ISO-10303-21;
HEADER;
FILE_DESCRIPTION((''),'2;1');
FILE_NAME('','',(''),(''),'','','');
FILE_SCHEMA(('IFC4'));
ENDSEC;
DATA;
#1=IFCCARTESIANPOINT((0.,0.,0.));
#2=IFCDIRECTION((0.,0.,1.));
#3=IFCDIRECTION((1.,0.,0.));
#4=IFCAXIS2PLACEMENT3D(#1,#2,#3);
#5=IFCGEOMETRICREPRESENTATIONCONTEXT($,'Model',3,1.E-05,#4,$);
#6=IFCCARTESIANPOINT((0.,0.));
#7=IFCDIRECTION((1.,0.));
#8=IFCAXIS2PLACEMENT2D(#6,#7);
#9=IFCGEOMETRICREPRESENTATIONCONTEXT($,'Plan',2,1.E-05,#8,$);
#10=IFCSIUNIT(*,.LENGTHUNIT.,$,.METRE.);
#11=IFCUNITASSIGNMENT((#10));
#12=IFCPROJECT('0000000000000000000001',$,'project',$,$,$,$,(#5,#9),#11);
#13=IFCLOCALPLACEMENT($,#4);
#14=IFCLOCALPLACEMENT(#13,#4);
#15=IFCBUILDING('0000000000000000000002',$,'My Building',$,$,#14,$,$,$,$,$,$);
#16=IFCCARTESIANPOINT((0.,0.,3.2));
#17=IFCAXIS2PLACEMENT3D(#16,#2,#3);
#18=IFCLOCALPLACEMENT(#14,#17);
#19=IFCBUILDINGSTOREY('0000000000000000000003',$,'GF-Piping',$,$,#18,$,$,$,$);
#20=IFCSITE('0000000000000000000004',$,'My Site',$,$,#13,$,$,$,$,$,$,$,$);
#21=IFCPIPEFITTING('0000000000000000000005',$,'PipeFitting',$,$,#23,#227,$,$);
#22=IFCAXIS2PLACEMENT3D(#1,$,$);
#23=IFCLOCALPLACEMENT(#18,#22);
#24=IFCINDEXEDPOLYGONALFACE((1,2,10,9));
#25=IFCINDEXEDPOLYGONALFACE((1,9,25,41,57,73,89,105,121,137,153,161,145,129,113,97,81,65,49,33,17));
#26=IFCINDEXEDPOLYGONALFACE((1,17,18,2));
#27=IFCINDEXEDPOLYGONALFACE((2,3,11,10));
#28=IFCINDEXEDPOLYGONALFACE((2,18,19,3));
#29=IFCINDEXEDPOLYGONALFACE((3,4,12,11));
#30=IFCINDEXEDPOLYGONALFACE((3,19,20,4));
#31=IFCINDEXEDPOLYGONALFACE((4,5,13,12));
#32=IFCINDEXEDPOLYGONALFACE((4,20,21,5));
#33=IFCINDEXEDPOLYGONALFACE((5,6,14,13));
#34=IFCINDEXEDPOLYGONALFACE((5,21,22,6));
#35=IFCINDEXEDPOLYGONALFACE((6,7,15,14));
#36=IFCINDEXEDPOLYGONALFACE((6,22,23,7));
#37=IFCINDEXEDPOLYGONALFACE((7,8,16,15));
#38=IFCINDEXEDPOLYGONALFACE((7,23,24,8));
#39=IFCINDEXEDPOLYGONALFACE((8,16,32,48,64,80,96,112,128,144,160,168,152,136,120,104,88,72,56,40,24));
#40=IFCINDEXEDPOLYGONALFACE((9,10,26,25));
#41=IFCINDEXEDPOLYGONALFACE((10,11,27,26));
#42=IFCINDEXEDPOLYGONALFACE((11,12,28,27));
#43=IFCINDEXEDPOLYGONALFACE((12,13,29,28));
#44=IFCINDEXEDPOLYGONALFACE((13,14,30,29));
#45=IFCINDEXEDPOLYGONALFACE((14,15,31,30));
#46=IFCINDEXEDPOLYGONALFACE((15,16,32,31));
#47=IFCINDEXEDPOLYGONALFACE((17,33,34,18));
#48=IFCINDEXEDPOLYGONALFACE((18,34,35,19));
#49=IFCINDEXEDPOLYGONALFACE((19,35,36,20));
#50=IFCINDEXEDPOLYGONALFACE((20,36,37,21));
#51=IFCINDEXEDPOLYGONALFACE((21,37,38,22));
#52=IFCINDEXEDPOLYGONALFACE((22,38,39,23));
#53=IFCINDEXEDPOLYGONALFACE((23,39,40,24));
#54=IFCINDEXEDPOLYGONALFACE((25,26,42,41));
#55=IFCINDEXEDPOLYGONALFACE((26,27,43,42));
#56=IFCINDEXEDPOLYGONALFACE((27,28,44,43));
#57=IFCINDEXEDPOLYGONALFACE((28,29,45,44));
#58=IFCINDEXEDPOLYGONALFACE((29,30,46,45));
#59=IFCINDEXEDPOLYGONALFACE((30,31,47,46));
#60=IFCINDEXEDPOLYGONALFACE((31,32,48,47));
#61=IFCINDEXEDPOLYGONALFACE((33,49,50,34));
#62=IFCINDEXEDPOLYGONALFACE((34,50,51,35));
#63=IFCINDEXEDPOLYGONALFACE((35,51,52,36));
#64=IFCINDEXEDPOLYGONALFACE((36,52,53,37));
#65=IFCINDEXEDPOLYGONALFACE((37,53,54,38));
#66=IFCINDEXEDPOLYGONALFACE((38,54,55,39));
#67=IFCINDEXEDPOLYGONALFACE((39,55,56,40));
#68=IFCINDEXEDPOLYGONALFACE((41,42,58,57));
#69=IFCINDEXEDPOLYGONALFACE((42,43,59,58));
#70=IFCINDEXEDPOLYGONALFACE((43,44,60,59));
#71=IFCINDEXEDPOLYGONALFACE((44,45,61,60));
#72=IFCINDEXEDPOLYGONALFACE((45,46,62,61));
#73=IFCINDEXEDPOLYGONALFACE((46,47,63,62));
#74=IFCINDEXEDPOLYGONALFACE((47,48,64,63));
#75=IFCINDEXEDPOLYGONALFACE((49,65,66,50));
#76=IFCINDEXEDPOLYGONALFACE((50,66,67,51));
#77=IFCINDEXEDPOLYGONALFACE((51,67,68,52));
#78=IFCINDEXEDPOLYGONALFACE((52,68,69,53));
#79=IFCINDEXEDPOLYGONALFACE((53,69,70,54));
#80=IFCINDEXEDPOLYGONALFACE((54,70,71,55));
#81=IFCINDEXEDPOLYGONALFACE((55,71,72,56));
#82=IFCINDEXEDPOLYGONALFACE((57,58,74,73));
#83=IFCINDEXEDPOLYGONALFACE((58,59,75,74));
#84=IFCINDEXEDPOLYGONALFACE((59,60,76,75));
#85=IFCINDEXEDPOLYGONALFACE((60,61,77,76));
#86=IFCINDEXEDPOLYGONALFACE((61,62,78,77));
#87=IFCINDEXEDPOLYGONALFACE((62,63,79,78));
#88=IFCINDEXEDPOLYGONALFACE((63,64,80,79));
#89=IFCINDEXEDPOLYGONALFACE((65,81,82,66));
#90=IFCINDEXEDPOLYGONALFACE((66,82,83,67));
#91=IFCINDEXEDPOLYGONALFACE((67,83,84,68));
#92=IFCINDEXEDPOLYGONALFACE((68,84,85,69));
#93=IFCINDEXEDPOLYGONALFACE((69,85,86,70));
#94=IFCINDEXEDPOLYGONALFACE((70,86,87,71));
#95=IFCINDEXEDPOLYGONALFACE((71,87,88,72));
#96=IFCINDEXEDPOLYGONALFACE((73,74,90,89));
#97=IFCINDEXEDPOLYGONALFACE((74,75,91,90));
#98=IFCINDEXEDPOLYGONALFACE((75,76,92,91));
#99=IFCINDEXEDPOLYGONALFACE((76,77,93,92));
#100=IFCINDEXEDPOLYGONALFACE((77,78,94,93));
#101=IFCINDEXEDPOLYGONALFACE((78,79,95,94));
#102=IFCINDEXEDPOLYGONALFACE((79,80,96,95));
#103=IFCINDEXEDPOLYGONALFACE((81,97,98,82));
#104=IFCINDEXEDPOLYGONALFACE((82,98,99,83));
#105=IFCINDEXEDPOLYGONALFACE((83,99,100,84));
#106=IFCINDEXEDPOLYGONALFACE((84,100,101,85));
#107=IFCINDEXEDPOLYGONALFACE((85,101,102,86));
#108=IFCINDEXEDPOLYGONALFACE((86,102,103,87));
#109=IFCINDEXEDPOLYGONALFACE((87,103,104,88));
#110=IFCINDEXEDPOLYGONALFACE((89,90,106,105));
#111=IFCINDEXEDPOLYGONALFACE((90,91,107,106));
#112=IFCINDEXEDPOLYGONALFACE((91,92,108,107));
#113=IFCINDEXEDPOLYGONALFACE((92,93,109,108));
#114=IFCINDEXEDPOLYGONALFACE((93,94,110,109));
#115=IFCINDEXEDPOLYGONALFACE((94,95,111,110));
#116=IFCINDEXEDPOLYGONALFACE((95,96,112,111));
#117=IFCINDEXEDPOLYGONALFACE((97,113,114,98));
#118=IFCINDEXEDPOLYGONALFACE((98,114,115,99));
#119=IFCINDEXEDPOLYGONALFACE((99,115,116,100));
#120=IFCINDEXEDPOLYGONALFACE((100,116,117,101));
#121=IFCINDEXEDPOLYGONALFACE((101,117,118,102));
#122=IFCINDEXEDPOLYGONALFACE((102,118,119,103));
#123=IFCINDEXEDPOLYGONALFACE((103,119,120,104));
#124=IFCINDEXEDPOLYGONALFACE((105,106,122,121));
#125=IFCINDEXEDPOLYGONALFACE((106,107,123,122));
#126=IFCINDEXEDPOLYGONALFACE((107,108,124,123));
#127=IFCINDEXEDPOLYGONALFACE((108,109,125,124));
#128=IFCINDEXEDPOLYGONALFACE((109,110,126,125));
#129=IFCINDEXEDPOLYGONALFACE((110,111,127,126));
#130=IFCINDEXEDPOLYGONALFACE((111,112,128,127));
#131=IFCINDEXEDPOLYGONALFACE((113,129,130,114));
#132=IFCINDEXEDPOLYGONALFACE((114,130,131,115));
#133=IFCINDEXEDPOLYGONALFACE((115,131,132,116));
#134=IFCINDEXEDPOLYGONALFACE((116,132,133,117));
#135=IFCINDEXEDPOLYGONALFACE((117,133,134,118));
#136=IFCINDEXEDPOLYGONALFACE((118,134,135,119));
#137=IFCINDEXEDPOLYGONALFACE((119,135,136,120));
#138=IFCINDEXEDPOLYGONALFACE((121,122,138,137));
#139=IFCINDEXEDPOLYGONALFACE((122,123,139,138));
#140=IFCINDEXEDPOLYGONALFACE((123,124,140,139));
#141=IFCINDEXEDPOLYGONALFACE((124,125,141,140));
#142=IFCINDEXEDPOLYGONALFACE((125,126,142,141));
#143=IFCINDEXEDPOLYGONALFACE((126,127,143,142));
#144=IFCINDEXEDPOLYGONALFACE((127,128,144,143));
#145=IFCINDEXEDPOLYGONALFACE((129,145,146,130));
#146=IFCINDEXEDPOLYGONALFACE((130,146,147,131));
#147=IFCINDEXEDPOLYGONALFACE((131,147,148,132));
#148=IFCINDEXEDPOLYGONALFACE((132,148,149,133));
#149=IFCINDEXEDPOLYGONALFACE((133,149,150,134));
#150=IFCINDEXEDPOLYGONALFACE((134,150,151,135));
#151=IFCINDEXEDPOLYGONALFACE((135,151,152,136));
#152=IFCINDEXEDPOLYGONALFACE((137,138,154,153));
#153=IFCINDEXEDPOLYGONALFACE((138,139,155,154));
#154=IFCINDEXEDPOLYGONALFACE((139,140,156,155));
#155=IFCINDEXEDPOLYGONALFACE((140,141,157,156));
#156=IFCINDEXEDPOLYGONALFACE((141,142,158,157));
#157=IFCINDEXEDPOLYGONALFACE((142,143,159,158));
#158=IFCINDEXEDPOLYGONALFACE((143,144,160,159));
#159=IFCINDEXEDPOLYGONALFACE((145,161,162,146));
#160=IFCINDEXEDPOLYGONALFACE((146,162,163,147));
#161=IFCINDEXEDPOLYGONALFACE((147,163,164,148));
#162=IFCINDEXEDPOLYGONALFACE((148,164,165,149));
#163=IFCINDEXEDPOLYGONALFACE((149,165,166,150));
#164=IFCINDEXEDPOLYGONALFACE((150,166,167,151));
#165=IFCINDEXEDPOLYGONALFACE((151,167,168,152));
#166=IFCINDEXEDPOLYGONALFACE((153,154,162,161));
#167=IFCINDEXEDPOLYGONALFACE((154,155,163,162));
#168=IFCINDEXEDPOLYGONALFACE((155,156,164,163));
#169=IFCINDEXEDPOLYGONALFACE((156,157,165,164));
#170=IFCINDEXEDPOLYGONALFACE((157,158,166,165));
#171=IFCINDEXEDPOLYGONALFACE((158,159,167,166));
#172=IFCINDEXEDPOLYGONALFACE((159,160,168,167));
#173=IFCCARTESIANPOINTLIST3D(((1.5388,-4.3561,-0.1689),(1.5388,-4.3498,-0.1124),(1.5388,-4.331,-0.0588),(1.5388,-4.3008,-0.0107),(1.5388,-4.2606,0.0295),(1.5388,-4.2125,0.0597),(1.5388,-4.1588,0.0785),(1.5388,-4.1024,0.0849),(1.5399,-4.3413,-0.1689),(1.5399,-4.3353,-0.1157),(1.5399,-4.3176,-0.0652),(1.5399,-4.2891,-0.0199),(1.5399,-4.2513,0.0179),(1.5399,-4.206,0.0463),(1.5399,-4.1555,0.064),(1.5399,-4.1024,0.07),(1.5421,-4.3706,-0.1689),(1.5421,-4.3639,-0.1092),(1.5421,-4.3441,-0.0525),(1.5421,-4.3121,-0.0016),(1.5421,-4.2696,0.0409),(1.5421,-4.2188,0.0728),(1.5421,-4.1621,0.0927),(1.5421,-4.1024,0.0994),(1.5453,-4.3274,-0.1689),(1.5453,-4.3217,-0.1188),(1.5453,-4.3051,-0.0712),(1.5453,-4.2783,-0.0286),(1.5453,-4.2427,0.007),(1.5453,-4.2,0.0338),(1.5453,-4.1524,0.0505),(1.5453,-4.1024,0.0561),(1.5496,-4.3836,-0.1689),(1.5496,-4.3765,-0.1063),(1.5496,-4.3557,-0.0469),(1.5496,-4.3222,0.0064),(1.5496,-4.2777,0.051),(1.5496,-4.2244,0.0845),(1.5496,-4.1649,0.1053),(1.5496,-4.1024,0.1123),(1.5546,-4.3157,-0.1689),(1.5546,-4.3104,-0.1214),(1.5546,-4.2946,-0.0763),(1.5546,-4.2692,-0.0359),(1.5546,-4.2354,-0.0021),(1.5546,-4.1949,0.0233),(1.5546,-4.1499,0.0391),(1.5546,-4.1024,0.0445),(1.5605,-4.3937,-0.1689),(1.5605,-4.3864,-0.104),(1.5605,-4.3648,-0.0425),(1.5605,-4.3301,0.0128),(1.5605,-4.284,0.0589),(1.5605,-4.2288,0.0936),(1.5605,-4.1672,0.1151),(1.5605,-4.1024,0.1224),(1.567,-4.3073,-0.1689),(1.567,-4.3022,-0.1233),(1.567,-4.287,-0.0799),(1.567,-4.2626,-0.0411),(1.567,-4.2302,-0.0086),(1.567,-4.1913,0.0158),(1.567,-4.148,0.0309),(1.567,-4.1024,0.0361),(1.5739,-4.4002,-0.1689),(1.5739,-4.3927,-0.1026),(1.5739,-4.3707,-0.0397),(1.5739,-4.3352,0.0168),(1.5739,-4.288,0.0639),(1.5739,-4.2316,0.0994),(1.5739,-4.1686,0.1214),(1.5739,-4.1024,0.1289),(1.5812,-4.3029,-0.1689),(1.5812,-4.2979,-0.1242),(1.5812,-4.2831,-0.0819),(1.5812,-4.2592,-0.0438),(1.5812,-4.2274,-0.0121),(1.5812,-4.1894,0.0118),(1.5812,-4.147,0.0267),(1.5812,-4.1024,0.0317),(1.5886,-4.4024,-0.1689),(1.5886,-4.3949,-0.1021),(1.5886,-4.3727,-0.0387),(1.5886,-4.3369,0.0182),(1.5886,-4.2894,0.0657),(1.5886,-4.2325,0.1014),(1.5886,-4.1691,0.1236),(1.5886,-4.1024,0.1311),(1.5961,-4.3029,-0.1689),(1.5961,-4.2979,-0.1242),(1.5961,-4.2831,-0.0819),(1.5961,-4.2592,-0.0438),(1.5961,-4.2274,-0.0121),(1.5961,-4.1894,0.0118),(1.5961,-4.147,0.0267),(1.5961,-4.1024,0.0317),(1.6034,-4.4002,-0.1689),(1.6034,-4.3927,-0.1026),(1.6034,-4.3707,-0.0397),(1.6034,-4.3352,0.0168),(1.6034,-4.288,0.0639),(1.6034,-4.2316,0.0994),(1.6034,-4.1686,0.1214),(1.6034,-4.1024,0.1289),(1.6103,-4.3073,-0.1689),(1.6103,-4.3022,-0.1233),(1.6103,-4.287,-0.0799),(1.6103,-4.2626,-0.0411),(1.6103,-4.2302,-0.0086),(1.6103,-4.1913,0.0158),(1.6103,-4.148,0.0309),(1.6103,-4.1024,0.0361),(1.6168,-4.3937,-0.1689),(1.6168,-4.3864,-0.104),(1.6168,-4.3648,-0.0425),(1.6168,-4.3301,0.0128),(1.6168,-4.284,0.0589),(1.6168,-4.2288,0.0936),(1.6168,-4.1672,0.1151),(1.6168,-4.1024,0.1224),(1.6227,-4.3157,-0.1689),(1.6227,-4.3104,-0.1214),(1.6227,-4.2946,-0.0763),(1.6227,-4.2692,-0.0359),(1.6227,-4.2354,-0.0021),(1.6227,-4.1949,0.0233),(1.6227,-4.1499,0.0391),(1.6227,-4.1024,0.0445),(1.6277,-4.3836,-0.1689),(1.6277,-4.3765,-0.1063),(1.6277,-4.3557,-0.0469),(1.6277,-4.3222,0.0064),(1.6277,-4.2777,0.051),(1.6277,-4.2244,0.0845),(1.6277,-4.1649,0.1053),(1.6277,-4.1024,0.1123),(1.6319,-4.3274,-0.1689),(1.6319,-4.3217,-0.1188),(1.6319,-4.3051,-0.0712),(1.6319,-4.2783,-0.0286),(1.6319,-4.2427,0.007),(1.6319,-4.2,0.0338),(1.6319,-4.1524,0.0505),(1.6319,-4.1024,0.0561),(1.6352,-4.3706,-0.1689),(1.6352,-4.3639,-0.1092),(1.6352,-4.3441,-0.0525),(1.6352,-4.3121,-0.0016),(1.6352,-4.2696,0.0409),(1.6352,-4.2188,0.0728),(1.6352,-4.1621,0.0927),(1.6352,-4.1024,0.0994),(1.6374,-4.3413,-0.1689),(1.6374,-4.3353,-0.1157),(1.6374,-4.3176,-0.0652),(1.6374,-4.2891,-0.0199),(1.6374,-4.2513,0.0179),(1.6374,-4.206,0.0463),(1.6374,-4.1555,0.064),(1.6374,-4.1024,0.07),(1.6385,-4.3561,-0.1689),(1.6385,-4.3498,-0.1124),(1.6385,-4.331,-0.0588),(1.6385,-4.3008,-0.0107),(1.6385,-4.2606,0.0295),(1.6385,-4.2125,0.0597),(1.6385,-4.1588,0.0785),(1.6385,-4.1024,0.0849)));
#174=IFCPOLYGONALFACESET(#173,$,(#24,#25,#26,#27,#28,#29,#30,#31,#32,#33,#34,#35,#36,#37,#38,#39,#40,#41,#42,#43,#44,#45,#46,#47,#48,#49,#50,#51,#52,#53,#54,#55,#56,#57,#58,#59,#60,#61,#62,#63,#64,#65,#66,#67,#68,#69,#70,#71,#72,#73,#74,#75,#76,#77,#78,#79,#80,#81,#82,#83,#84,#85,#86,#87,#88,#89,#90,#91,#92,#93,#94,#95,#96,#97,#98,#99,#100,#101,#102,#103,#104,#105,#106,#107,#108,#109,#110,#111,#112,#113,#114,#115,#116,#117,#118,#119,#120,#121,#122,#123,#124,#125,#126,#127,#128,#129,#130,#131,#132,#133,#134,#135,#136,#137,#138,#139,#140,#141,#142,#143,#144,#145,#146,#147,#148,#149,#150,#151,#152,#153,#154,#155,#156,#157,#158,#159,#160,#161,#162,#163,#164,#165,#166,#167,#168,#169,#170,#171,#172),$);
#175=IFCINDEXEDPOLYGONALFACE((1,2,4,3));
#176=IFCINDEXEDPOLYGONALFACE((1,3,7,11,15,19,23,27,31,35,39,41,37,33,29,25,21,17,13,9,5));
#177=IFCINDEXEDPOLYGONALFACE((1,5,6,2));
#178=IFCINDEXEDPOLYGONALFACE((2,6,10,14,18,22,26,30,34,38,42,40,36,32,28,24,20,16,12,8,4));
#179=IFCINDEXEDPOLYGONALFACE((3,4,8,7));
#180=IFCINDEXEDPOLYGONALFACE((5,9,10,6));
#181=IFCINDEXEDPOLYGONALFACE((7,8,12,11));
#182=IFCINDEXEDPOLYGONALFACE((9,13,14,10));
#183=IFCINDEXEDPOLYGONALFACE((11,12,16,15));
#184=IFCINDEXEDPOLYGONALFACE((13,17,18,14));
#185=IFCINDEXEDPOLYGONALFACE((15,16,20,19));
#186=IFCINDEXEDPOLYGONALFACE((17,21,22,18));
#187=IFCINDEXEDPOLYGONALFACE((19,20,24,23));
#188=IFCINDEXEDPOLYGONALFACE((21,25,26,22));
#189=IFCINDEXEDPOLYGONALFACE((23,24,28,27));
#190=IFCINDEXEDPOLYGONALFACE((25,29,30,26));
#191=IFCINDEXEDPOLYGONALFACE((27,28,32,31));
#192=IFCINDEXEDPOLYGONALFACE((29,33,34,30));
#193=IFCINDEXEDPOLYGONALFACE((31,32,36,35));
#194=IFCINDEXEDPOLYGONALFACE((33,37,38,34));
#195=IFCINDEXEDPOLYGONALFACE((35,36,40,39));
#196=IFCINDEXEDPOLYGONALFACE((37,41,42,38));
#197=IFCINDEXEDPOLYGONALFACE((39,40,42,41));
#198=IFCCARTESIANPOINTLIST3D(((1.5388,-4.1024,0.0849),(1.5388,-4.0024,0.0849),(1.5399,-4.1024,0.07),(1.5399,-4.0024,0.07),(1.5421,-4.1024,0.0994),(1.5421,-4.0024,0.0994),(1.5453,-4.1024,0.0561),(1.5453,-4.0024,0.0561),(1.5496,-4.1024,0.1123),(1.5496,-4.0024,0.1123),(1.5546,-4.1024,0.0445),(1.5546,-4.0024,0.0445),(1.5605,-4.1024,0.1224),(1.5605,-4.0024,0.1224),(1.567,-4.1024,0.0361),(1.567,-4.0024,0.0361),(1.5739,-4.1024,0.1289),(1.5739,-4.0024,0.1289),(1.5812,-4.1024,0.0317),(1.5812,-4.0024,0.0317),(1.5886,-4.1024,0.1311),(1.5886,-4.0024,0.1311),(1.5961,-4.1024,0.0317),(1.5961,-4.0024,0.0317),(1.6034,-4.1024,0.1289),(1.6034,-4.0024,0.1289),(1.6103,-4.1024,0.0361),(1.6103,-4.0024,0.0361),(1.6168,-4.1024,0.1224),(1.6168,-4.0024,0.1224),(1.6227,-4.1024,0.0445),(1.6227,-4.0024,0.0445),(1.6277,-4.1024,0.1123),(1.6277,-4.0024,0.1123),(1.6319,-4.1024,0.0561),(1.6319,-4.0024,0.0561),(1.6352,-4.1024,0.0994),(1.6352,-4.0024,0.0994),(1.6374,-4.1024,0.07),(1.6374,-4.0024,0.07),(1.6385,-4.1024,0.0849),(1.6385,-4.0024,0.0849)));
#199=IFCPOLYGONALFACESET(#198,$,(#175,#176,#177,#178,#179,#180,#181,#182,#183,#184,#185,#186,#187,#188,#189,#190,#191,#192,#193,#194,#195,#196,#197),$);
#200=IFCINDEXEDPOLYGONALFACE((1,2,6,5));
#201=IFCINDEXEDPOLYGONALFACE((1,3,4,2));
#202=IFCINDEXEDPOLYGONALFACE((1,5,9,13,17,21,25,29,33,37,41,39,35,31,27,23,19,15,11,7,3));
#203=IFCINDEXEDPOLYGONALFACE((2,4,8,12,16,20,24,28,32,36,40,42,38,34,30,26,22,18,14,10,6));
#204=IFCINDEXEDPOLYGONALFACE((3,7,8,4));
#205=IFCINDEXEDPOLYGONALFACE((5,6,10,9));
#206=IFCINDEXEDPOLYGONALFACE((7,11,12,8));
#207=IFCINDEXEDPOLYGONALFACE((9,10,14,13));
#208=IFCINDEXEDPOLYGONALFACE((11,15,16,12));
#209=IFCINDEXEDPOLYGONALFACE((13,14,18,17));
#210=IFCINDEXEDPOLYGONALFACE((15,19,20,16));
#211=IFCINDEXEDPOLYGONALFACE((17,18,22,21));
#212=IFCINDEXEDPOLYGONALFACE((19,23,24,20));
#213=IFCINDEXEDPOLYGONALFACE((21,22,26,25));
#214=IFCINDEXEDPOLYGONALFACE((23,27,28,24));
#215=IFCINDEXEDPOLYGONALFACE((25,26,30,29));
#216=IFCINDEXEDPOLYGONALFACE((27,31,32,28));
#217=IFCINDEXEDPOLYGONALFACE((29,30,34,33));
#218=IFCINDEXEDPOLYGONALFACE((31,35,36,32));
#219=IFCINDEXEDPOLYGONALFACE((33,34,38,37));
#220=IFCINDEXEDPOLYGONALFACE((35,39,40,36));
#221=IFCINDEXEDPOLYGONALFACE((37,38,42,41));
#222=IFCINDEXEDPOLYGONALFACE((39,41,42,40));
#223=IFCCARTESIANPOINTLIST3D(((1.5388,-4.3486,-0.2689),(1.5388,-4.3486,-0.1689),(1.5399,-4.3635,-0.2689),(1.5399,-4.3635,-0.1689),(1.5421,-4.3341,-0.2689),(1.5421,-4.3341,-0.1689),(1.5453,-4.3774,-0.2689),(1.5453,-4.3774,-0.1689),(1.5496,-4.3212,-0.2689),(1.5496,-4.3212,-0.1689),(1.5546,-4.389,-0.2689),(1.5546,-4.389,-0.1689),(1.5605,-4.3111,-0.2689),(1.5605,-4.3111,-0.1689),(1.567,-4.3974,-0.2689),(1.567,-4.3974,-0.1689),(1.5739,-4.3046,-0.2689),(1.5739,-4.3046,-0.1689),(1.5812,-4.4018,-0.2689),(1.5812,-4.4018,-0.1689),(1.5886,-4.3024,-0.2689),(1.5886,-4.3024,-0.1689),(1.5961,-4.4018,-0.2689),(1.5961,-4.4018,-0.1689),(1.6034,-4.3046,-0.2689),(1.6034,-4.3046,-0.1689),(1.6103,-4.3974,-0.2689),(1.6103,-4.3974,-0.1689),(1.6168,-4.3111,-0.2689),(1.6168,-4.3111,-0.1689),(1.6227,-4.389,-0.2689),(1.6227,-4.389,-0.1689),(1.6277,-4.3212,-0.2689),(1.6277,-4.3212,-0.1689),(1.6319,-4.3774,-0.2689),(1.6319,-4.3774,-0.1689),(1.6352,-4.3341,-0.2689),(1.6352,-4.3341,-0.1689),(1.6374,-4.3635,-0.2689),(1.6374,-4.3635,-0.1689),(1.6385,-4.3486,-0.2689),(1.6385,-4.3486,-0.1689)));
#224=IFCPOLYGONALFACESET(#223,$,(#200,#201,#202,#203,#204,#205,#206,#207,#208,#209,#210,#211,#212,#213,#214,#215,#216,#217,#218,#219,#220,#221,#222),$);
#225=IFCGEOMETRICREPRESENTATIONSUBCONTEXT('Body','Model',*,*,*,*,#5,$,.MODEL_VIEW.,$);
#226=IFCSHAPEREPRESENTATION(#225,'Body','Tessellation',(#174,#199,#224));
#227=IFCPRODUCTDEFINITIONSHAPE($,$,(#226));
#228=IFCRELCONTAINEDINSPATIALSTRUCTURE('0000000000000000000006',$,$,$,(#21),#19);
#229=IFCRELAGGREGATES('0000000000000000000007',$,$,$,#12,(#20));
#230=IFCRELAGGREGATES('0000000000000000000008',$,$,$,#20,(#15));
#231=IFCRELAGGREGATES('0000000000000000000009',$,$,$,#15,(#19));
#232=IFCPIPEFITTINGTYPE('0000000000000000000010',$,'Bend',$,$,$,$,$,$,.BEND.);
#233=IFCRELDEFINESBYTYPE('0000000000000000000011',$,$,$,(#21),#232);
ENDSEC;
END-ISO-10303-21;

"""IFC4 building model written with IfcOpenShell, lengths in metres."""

from ifc_helpers import new_model, entity, si_unit, frame, origin_with_axes, origin_2d_with_axis, place, context, subcontext, project, spatial, circle, extrude, source, transform, mapped, type_object, type_shapes, element, save


model = new_model("IFC4")

# Units and contexts
model_context = context("Model", 3, precision=1e-05, world=origin_with_axes())
plan_context = context("Plan", 2, precision=1e-05, world=origin_2d_with_axis())
body_context = subcontext(model_context, "Body", "Model", "MODEL_VIEW")
ifc_project = project(units=[si_unit("LENGTHUNIT", "METRE")], contexts=[model_context, plan_context])

# Site, building, storey
site_placement = place(None, origin_with_axes())
site = spatial("IfcSite", under=ifc_project, at=site_placement, Name="My Site")
building_placement = place(site_placement, origin_with_axes())
building = spatial("IfcBuilding", under=site, at=building_placement, Name="My Building")
storey_placement = place(building_placement, frame((0.0, 0.0, 3.2), z_axis=(0.0, 0.0, 1.0), x_axis=(1.0, 0.0, 0.0)))
storey = spatial("IfcBuildingStorey", under=building, at=storey_placement, Name="GF-Piping")

# Pipe fitting
pipe_fitting_type = type_object("IfcPipeFittingType", Name="Bend", PredefinedType="BEND")
shared_shape = source(origin_with_axes(), body_context, "Body", "SolidModel", [
    entity("IfcSweptDiskSolid", entity("IfcIndexedPolyCurve", entity("IfcCartesianPointList3D", [[0.0, 0.0, 0.1], [-0.0732, 0.0, 0.2768], [-0.25, 0.0, 0.35]]), [entity("IfcArcIndex", [1, 2, 3])]), 0.05),
    extrude(circle(Radius=0.05), origin_with_axes(), (0.0, 0.0, 1.0), 0.1),
    extrude(circle(Radius=0.05), frame((-0.25, 0.0, 0.35), z_axis=(-1.0, 0.0, 0.0), x_axis=(0.0, 0.0, -1.0)), (0.0, 0.0, 1.0), 0.1),
])
type_shapes(pipe_fitting_type, [shared_shape])
for number, where, z_axis, x_axis, name in (
    (1, (1.5886, -4.0024, 0.0811), (0.0, -1.0, 0.0), (0.0, 0.0, 1.0), "PipeFitting"),
):
    element("IfcPipeFitting", number, at=place(storey_placement, frame(where, z_axis=z_axis, x_axis=x_axis)), inside=storey, type_object=pipe_fitting_type, Name=name, context=body_context, shape_type="MappedRepresentation", body=[
        mapped(shared_shape, transform((0.0, 0.0, 0.0), x_axis=(1.0, 0.0, 0.0), y_axis=(0.0, 1.0, 0.0), z_axis=(0.0, 0.0, 1.0), scale=1.0)),
    ])

save(model, "model.ifc")
